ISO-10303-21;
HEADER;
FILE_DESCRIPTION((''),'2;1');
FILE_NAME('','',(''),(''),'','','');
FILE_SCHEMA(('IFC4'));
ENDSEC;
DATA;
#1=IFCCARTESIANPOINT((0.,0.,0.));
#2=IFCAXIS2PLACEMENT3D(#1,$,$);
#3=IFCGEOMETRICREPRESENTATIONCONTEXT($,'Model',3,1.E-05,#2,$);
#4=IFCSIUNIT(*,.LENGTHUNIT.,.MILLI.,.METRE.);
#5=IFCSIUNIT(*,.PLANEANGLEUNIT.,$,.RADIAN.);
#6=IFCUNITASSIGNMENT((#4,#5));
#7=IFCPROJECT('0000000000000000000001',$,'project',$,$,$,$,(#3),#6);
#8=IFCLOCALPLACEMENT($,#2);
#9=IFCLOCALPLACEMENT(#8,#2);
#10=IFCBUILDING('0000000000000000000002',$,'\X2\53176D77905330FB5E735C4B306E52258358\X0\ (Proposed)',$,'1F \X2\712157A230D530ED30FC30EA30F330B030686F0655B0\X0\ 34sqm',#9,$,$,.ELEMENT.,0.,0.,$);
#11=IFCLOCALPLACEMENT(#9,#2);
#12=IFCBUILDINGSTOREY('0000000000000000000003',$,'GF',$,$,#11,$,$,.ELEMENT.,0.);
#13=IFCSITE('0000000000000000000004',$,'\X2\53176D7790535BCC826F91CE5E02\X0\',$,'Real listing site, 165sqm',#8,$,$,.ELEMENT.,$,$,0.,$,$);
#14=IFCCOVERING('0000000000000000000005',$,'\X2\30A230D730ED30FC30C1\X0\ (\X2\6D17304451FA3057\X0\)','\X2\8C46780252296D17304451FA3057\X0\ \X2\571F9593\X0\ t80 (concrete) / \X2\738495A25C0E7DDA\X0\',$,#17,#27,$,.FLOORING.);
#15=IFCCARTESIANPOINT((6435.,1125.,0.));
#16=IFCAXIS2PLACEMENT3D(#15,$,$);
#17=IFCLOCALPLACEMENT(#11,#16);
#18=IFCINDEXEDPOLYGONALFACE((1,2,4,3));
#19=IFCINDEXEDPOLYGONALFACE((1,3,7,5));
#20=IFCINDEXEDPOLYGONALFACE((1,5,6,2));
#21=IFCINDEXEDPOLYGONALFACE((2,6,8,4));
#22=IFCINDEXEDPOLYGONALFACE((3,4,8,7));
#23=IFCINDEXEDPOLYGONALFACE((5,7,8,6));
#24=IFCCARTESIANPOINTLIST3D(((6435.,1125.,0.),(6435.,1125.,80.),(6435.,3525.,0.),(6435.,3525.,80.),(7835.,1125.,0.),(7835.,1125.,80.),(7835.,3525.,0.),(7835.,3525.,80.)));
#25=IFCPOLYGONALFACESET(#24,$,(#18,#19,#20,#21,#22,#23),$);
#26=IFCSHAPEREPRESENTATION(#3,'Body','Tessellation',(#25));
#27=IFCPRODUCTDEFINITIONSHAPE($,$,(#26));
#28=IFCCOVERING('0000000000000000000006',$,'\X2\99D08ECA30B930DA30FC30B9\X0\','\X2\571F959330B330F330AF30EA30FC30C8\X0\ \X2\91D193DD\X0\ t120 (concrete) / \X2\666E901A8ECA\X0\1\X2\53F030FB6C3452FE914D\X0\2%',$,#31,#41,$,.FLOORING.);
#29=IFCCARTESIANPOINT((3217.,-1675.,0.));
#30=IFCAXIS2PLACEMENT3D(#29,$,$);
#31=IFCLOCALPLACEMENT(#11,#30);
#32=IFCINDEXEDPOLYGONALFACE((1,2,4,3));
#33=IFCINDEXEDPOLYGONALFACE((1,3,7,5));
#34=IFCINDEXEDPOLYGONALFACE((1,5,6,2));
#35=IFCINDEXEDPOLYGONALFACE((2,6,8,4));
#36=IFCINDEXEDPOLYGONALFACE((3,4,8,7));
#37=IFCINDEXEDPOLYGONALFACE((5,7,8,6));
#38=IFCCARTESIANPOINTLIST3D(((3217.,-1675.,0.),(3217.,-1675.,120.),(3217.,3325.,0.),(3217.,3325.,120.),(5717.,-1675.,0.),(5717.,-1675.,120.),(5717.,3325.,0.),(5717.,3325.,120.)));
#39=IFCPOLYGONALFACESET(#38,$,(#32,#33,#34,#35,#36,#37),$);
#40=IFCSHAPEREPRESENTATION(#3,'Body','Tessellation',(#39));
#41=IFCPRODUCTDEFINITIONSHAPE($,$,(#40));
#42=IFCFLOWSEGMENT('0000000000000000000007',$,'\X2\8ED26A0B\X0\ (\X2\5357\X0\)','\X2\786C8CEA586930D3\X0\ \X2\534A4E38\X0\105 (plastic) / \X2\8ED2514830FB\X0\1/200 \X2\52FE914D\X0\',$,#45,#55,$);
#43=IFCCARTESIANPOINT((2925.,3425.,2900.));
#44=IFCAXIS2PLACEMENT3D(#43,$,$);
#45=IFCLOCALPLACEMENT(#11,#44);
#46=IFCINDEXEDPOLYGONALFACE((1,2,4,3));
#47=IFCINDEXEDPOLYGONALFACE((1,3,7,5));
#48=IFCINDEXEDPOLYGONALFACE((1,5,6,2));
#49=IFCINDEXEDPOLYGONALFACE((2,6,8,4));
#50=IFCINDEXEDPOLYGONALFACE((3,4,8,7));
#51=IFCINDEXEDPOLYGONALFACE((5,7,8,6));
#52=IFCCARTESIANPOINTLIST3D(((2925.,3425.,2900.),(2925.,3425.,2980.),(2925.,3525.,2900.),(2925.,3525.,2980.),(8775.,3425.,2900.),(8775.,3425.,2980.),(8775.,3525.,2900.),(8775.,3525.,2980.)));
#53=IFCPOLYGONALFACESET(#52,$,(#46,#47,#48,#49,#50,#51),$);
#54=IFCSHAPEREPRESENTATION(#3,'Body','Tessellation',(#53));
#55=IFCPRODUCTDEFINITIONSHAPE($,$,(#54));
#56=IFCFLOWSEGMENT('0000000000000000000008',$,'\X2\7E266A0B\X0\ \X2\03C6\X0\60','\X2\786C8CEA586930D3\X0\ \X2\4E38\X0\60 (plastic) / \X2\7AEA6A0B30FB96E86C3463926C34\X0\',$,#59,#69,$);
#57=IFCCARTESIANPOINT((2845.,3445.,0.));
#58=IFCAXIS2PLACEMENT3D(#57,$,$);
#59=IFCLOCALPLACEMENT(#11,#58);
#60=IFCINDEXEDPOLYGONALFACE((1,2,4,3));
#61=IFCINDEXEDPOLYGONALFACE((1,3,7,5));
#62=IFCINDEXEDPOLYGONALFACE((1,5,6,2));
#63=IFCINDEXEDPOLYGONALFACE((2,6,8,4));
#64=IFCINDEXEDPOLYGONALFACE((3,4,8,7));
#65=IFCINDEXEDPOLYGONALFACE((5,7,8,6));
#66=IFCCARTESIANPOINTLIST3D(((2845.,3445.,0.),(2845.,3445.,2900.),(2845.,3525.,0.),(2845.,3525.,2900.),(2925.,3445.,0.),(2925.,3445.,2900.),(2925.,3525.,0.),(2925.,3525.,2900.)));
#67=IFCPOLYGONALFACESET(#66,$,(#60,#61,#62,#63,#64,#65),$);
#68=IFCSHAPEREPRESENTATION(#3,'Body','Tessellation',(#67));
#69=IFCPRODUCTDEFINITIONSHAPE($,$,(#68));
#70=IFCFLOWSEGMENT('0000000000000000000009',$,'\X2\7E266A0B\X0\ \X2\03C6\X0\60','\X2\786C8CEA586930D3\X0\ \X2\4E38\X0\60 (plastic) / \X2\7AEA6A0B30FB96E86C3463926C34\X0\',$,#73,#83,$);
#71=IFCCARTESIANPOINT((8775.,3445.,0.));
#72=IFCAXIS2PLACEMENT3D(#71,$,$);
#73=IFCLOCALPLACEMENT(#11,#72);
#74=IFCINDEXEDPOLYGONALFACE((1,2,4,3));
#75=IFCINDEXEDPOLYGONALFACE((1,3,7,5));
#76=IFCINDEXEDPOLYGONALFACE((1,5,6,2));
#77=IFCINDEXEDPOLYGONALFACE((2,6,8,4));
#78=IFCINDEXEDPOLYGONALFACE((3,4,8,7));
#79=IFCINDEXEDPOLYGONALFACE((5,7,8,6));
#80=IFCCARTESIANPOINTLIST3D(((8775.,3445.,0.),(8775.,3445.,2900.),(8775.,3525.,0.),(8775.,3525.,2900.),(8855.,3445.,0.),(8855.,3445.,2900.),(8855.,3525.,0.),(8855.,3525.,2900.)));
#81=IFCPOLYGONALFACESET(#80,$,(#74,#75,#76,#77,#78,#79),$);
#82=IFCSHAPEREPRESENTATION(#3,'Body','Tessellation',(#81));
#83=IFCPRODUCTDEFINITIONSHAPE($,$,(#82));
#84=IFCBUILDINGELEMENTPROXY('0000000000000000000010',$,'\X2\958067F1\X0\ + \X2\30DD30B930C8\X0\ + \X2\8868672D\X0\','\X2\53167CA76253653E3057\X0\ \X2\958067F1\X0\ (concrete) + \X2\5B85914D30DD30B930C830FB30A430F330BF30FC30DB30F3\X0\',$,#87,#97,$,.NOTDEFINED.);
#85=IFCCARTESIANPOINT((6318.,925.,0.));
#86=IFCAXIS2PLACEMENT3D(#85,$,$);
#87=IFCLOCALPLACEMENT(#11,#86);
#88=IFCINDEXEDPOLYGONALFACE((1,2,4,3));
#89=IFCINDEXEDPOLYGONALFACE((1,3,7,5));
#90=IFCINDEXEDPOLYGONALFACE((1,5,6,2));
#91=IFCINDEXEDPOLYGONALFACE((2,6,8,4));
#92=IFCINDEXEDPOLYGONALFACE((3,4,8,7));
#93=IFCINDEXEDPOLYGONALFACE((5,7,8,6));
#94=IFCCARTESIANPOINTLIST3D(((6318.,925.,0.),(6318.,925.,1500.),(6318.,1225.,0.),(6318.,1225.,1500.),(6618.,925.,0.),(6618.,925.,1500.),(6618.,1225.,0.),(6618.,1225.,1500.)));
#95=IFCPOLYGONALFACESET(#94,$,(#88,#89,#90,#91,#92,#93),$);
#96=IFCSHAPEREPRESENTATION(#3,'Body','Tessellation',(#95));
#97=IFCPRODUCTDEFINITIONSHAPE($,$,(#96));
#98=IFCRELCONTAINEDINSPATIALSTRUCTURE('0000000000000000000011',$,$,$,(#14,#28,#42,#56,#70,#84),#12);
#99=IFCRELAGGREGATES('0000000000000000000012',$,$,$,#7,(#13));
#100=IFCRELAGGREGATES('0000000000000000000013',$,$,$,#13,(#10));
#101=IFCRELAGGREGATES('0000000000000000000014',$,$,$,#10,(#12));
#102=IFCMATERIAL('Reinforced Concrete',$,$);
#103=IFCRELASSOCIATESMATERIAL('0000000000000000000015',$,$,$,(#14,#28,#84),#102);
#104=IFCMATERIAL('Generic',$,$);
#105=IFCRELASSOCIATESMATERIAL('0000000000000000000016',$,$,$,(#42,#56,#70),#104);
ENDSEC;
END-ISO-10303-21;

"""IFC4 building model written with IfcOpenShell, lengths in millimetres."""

from ifc_helpers import new_model, si_unit, frame, frame_2d, origin, place, context, project, spatial, rectangle, extrude, material, element, save


model = new_model("IFC4")

# Units and contexts
model_context = context("Model", 3, precision=1e-05, world=origin())
ifc_project = project(units=[si_unit("LENGTHUNIT", "METRE", prefix="MILLI"), si_unit("PLANEANGLEUNIT", "RADIAN")], contexts=[model_context])

# Site, building, storey
site_placement = place(None, origin())
site = spatial("IfcSite", under=ifc_project, at=site_placement, Name="北海道富良野市", ObjectType="Real listing site, 165sqm", CompositionType="ELEMENT", RefElevation=0.0)
building_placement = place(site_placement, origin())
building = spatial("IfcBuilding", under=site, at=building_placement, Name="北海道・平屋の別荘 (Proposed)", ObjectType="1F 無垢フローリングと漆喰 34sqm", CompositionType="ELEMENT", ElevationOfRefHeight=0.0, ElevationOfTerrain=0.0)
storey_placement = place(building_placement, origin())
storey = spatial("IfcBuildingStorey", under=building, at=storey_placement, Name="GF", CompositionType="ELEMENT", Elevation=0.0)

# Shared definitions
ifc_material_1 = material(Name="Reinforced Concrete")

# Coverings
ifc_material_2 = material(Name="Generic")
covering_1_placement = place(storey_placement, frame((6435.0, 1125.0, 0.0)))
element("IfcCovering", 1, at=covering_1_placement, inside=storey, material=ifc_material_1, Name="アプローチ (洗い出し)", Description="豆砂利洗い出し 土間 t80 (concrete) / 玄関導線", PredefinedType="FLOORING", context=model_context, shape_type="SweptSolid", body=[
    extrude(rectangle(XDim=1400.0, YDim=2400.0, at=frame_2d((700.0, 1200.0))), frame((6435.0, 1125.0, 0.0)), (0.0, 0.0, 1.0), 80.0),
])
covering_2_placement = place(storey_placement, frame((3217.0, -1675.0, 0.0)))
element("IfcCovering", 2, at=covering_2_placement, inside=storey, material=ifc_material_1, Name="駐車スペース", Description="土間コンクリート 金鏝 t120 (concrete) / 普通車1台・水勾配2%", PredefinedType="FLOORING", context=model_context, shape_type="SweptSolid", body=[
    extrude(rectangle(XDim=2500.0, YDim=5000.0, at=frame_2d((1250.0, 2500.0))), frame((3217.0, -1675.0, 0.0)), (0.0, 0.0, 1.0), 120.0),
])

# Flow segments
flow_segment_1_placement = place(storey_placement, frame((2925.0, 3425.0, 2900.0)))
element("IfcFlowSegment", 3, at=flow_segment_1_placement, inside=storey, material=ifc_material_2, Name="軒樋 (南)", Description="硬質塩ビ 半丸105 (plastic) / 軒先・1/200 勾配", context=model_context, shape_type="SweptSolid", body=[
    extrude(rectangle(XDim=5850.0, YDim=100.0, at=frame_2d((2925.0, 50.0))), frame((2925.0, 3425.0, 2900.0)), (0.0, 0.0, 1.0), 80.0),
])
flow_segment_2_placement = place(storey_placement, frame((2845.0, 3445.0, 0.0)))
element("IfcFlowSegment", 4, at=flow_segment_2_placement, inside=storey, material=ifc_material_2, Name="縦樋 φ60", Description="硬質塩ビ 丸60 (plastic) / 竪樋・雨水排水", context=model_context, shape_type="SweptSolid", body=[
    extrude(rectangle(XDim=80.0, YDim=80.0, at=frame_2d((40.0, 40.0))), frame((2845.0, 3445.0, 0.0)), (0.0, 0.0, 1.0), 2900.0),
])
flow_segment_3_placement = place(storey_placement, frame((8775.0, 3445.0, 0.0)))
element("IfcFlowSegment", 5, at=flow_segment_3_placement, inside=storey, material=ifc_material_2, Name="縦樋 φ60", Description="硬質塩ビ 丸60 (plastic) / 竪樋・雨水排水", context=model_context, shape_type="SweptSolid", body=[
    extrude(rectangle(XDim=80.0, YDim=80.0, at=frame_2d((40.0, 40.0))), frame((8775.0, 3445.0, 0.0)), (0.0, 0.0, 1.0), 2900.0),
])

# Building element proxy
proxy_placement = place(storey_placement, frame((6318.0, 925.0, 0.0)))
element("IfcBuildingElementProxy", 6, at=proxy_placement, inside=storey, material=ifc_material_1, Name="門柱 + ポスト + 表札", Description="化粧打放し 門柱 (concrete) + 宅配ポスト・インターホン", PredefinedType="NOTDEFINED", context=model_context, shape_type="SweptSolid", body=[
    extrude(rectangle(XDim=300.0, YDim=300.0, at=frame_2d((150.0, 150.0))), frame((6318.0, 925.0, 0.0)), (0.0, 0.0, 1.0), 1500.0),
])

save(model, "model.ifc")
